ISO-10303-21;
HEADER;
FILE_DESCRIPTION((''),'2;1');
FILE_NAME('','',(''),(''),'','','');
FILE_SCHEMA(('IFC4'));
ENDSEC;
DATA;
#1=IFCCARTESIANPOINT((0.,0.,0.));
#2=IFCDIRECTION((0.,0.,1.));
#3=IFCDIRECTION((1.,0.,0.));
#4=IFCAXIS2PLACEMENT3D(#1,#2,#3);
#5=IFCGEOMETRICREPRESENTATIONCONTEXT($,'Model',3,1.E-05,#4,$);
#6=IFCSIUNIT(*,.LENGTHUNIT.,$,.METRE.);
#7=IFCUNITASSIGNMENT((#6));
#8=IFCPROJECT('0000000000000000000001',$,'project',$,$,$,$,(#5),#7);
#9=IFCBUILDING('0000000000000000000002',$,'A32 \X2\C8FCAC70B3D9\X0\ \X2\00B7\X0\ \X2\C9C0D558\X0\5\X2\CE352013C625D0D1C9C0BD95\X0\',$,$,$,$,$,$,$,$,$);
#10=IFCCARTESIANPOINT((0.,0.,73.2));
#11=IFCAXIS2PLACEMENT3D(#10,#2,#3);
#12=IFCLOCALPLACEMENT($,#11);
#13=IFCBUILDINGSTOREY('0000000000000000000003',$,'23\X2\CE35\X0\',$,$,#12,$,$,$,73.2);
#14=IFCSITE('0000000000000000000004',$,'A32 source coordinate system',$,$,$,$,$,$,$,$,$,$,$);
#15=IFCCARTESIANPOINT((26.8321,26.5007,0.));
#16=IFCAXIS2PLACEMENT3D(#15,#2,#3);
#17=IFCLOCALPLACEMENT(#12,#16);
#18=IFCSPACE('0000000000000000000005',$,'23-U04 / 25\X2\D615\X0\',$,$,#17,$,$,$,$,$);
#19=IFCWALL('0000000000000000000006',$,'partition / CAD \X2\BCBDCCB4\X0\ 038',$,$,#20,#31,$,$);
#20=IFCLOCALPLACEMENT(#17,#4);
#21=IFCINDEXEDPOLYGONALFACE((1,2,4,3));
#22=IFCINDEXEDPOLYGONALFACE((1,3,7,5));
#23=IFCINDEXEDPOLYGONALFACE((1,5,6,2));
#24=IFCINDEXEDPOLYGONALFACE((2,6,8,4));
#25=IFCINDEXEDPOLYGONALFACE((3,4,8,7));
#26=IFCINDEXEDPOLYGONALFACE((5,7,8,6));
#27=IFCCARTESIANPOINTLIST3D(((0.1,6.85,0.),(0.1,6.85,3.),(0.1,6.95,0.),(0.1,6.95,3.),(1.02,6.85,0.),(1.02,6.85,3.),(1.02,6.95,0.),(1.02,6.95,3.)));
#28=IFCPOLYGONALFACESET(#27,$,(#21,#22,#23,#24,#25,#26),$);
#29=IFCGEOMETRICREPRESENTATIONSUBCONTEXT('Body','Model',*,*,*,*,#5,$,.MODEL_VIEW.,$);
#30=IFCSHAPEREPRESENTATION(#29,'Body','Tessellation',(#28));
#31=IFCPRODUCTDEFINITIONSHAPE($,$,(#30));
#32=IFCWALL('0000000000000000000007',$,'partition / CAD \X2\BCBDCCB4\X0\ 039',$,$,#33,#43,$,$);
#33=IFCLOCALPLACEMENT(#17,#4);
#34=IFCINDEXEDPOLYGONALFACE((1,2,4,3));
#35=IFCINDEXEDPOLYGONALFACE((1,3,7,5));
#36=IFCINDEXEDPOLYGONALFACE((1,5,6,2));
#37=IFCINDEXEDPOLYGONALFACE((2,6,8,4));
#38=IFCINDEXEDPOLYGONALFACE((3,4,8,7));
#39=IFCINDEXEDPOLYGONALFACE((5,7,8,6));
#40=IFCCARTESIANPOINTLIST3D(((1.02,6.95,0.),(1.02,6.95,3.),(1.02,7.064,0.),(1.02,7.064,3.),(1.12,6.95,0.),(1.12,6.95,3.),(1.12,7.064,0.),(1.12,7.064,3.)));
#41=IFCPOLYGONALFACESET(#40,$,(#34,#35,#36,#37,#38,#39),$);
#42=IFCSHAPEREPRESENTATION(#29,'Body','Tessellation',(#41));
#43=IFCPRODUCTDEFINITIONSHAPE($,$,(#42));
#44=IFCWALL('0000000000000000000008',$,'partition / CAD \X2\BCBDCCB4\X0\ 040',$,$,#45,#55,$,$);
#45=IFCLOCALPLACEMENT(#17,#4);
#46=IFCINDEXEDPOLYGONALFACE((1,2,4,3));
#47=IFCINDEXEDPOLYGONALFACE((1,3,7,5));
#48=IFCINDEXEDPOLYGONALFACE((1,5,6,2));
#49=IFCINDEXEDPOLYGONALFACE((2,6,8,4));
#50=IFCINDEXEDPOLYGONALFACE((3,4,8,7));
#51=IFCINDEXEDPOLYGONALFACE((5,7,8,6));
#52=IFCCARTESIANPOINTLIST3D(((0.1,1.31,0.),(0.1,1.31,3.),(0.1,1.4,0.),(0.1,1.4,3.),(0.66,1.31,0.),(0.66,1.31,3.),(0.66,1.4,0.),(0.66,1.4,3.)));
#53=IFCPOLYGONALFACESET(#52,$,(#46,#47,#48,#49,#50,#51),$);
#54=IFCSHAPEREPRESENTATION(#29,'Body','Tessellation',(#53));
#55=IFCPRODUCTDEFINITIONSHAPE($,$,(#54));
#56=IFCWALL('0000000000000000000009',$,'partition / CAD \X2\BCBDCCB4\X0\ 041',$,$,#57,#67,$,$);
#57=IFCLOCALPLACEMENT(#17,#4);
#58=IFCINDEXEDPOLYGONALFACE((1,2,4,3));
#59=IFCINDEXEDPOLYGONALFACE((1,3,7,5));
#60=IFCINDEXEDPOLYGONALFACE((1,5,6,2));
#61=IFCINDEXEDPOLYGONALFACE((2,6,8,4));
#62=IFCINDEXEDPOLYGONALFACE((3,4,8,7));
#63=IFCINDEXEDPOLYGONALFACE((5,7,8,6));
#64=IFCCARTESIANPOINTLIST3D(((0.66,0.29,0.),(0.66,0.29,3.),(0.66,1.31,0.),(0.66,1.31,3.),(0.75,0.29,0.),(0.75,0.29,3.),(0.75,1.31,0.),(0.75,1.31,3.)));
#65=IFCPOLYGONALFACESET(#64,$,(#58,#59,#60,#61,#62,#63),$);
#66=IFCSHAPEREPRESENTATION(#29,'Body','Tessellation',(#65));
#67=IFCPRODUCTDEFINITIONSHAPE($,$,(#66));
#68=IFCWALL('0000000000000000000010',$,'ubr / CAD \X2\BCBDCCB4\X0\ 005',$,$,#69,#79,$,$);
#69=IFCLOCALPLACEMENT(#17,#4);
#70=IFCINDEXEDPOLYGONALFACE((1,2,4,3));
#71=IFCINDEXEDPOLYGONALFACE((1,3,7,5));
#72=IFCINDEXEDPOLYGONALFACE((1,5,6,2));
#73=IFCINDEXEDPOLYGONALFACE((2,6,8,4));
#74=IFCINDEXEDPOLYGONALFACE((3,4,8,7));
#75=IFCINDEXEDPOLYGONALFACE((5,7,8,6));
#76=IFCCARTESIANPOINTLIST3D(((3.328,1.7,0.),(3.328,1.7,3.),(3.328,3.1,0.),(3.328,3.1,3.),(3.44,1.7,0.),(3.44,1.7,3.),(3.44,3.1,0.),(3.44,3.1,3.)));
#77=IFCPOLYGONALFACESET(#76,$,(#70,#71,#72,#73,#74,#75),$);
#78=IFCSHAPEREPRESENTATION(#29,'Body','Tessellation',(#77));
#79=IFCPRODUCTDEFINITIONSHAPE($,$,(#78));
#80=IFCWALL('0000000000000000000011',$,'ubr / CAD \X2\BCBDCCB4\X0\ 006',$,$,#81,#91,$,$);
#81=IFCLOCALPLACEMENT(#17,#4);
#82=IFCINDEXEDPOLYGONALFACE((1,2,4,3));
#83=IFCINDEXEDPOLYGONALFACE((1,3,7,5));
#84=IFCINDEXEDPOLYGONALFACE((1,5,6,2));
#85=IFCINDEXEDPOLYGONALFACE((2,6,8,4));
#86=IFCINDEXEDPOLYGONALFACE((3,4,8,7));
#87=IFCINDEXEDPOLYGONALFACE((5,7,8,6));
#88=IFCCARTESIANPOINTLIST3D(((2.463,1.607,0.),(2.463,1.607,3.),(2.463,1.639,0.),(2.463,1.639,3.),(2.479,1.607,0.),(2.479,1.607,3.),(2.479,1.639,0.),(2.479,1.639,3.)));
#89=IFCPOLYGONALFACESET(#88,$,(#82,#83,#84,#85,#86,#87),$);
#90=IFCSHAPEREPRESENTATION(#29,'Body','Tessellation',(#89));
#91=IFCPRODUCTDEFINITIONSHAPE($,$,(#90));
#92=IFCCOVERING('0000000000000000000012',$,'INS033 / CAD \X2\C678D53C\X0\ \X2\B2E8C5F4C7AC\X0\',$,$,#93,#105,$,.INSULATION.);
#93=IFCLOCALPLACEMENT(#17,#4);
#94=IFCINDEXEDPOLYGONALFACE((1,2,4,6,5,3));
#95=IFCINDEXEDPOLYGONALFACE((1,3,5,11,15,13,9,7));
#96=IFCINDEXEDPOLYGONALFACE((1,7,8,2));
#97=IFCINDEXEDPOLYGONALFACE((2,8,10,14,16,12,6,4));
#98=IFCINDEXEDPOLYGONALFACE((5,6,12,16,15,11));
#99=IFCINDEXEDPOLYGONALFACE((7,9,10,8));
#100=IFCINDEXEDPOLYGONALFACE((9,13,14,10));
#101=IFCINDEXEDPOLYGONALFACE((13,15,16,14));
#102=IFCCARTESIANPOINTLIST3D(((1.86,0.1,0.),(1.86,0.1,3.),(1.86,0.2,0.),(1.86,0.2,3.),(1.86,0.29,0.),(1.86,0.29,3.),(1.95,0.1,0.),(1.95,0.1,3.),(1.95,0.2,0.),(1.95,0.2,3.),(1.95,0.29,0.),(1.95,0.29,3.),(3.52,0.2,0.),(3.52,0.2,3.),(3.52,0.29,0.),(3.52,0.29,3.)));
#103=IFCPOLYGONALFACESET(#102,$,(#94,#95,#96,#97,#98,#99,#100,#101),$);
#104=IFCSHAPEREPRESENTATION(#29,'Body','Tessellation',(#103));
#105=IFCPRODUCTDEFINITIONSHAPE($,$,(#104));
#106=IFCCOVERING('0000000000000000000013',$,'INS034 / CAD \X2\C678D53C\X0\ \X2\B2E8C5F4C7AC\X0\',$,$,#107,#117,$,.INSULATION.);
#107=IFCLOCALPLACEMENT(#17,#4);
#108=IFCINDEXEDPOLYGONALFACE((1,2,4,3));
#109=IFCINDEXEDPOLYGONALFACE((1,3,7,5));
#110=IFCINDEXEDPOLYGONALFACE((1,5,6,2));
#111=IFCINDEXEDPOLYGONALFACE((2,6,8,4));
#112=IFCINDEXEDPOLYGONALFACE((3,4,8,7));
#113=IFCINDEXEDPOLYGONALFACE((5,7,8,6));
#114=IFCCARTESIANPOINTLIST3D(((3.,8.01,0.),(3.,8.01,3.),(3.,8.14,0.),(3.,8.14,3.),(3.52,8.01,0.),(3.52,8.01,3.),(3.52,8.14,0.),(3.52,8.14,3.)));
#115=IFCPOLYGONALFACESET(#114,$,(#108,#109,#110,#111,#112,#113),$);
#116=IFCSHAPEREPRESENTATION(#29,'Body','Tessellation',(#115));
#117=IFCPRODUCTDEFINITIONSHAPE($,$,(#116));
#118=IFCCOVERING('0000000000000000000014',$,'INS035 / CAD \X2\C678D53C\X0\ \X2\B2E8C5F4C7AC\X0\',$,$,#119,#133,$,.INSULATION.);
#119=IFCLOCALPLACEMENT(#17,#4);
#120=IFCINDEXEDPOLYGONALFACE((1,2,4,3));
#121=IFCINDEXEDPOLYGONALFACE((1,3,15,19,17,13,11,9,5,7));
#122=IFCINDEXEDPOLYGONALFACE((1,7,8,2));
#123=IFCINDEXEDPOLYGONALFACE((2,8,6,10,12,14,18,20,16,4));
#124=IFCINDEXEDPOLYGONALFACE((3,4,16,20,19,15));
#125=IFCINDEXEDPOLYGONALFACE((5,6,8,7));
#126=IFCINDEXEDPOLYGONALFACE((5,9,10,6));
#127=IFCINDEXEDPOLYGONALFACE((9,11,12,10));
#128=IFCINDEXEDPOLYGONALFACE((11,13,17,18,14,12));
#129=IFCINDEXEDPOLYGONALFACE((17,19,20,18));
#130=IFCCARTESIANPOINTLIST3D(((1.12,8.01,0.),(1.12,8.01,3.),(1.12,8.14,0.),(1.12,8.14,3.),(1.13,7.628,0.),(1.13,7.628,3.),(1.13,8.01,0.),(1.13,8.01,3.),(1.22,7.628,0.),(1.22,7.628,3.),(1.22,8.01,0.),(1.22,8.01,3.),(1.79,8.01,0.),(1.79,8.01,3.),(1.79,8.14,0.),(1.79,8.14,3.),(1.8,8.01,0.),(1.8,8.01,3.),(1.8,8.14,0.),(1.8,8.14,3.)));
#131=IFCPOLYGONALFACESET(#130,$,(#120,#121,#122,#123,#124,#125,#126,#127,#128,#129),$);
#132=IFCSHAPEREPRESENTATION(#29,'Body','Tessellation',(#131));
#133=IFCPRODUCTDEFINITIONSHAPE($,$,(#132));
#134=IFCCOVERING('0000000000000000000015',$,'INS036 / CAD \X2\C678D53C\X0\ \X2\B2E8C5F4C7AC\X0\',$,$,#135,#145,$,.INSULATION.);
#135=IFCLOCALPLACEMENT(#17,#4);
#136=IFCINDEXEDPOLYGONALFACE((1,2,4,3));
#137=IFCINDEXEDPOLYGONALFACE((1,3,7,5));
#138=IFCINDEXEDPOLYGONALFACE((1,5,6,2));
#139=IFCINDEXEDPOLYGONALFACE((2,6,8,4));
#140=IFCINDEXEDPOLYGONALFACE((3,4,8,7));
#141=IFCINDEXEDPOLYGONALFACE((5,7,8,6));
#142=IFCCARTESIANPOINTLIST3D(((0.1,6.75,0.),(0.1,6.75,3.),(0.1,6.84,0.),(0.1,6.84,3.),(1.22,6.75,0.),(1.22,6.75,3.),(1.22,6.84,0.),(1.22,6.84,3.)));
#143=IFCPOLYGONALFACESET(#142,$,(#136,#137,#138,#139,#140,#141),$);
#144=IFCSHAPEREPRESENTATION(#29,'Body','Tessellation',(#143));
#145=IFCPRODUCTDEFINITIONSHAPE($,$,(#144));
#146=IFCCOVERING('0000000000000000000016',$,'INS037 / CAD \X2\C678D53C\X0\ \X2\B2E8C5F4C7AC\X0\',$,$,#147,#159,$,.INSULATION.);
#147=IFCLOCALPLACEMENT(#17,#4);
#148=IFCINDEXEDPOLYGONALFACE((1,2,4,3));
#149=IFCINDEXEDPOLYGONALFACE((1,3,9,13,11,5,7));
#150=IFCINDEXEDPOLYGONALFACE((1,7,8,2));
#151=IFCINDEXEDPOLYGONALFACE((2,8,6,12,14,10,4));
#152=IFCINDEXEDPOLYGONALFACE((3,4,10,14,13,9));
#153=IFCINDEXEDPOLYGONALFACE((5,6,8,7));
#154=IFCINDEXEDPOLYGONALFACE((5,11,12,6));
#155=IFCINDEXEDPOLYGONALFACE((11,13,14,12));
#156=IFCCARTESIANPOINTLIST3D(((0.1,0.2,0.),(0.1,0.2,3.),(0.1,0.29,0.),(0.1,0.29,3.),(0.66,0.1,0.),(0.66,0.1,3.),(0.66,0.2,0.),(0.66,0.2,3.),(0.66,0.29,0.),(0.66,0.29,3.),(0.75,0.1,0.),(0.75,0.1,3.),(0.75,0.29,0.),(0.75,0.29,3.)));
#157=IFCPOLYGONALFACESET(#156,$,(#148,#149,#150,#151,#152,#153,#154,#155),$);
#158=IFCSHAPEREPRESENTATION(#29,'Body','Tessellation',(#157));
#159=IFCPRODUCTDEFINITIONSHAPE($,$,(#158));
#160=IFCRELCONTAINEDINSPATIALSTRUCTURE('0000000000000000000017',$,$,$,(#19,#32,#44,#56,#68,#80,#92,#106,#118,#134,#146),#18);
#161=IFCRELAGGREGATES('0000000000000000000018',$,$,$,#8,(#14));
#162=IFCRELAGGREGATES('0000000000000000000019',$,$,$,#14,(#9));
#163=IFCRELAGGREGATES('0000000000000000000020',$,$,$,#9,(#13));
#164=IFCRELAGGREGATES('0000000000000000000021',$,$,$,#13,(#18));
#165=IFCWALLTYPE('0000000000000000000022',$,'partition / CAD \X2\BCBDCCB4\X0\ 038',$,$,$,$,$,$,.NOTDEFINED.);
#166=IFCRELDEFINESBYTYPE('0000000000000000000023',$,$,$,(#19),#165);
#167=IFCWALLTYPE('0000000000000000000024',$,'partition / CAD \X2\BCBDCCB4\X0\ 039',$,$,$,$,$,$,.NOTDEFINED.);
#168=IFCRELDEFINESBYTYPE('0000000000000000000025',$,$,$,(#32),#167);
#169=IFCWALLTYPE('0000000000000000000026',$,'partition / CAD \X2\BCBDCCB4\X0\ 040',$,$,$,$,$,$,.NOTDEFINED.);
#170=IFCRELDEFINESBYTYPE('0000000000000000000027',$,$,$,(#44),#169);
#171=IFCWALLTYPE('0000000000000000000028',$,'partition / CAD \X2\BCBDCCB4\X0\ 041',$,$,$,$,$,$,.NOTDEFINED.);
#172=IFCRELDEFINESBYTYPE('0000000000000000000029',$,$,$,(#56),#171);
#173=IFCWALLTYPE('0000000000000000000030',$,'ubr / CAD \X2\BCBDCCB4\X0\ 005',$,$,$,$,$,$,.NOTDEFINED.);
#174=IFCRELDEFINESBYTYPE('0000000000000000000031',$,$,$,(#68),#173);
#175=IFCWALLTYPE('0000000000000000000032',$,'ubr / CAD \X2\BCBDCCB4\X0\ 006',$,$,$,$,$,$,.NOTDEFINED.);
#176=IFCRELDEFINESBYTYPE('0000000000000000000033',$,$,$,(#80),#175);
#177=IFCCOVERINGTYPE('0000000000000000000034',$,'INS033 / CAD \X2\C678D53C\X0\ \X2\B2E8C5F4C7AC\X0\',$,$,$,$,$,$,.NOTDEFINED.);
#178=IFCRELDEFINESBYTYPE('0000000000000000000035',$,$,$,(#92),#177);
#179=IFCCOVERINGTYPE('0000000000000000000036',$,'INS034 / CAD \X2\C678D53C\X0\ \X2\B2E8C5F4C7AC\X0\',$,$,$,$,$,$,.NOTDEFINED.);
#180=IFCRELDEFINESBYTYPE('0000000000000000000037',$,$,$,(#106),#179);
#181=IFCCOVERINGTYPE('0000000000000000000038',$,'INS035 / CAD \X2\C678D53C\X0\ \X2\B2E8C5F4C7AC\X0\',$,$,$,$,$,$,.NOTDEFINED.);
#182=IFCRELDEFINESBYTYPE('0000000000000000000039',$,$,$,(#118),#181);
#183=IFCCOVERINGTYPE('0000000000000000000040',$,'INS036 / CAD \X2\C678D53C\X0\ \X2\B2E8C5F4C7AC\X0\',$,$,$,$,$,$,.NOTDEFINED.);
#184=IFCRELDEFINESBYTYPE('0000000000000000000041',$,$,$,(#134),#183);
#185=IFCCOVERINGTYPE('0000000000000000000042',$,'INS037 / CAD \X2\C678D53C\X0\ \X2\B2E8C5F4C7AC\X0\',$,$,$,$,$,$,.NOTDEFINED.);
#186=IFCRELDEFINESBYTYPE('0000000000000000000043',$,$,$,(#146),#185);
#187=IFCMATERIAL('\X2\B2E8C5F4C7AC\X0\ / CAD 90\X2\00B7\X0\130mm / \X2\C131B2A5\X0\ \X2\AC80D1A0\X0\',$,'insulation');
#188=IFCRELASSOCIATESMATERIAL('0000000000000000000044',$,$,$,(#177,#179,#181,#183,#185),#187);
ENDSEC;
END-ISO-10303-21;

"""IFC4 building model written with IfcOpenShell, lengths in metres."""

from ifc_helpers import new_model, si_unit, frame, origin, origin_with_axes, place, context, subcontext, project, spatial, polyline, outline, extrude, source, transform, mapped, material, type_object, type_shapes, element, save


model = new_model("IFC4")

# Units and contexts
model_context = context("Model", 3, precision=1e-05, world=origin_with_axes())
body_context = subcontext(model_context, "Body", "Model", "MODEL_VIEW")
ifc_project = project(units=[si_unit("LENGTHUNIT", "METRE")], contexts=[model_context])

# Site, building, storey, space
storey_placement = place(None, frame((0.0, 0.0, 73.2), z_axis=(0.0, 0.0, 1.0), x_axis=(1.0, 0.0, 0.0)))
space_placement = place(storey_placement, frame((26.8321, 26.5007, 0.0), z_axis=(0.0, 0.0, 1.0), x_axis=(1.0, 0.0, 0.0)))
site = spatial("IfcSite", under=ifc_project, Name="A32 source coordinate system")
building = spatial("IfcBuilding", under=site, Name="A32 주거동 · 지하5층–옥탑지붕")
storey = spatial("IfcBuildingStorey", under=building, at=storey_placement, Name="23층", Elevation=73.2)
space = spatial("IfcSpace", under=storey, at=space_placement, Name="23-U04 / 25형")

# Walls
wall_type_1 = type_object("IfcWallType", Name="partition / CAD 벽체 038", PredefinedType="NOTDEFINED")
shared_shape_1 = source(origin(), body_context, "Body", "SweptSolid", [
    extrude(outline(polyline([(0.1, 6.95), (1.02, 6.95), (1.02, 6.85), (0.1, 6.85), (0.1, 6.95)])), origin(), (0.0, 0.0, 1.0), 3.0),
])
type_shapes(wall_type_1, [shared_shape_1])
wall_1_placement = place(space_placement, origin_with_axes())
element("IfcWall", 1, at=wall_1_placement, inside=space, type_object=wall_type_1, Name="partition / CAD 벽체 038", context=body_context, shape_type="MappedRepresentation", body=[
    mapped(shared_shape_1, transform((0.0, 0.0, 0.0), scale=1.0)),
])
wall_type_2 = type_object("IfcWallType", Name="partition / CAD 벽체 039", PredefinedType="NOTDEFINED")
shared_shape_2 = source(origin(), body_context, "Body", "SweptSolid", [
    extrude(outline(polyline([(1.02, 6.95), (1.02, 7.064), (1.12, 7.064), (1.12, 6.95), (1.02, 6.95)])), origin(), (0.0, 0.0, 1.0), 3.0),
])
type_shapes(wall_type_2, [shared_shape_2])
wall_2_placement = place(space_placement, origin_with_axes())
element("IfcWall", 2, at=wall_2_placement, inside=space, type_object=wall_type_2, Name="partition / CAD 벽체 039", context=body_context, shape_type="MappedRepresentation", body=[
    mapped(shared_shape_2, transform((0.0, 0.0, 0.0), scale=1.0)),
])
wall_type_3 = type_object("IfcWallType", Name="partition / CAD 벽체 040", PredefinedType="NOTDEFINED")
shared_shape_3 = source(origin(), body_context, "Body", "SweptSolid", [
    extrude(outline(polyline([(0.1, 1.4), (0.66, 1.4), (0.66, 1.31), (0.1, 1.31), (0.1, 1.4)])), origin(), (0.0, 0.0, 1.0), 3.0),
])
type_shapes(wall_type_3, [shared_shape_3])
wall_3_placement = place(space_placement, origin_with_axes())
element("IfcWall", 3, at=wall_3_placement, inside=space, type_object=wall_type_3, Name="partition / CAD 벽체 040", context=body_context, shape_type="MappedRepresentation", body=[
    mapped(shared_shape_3, transform((0.0, 0.0, 0.0), scale=1.0)),
])
wall_type_4 = type_object("IfcWallType", Name="partition / CAD 벽체 041", PredefinedType="NOTDEFINED")
shared_shape_4 = source(origin(), body_context, "Body", "SweptSolid", [
    extrude(outline(polyline([(0.75, 1.31), (0.75, 0.29), (0.66, 0.29), (0.66, 1.31), (0.75, 1.31)])), origin(), (0.0, 0.0, 1.0), 3.0),
])
type_shapes(wall_type_4, [shared_shape_4])
wall_4_placement = place(space_placement, origin_with_axes())
element("IfcWall", 4, at=wall_4_placement, inside=space, type_object=wall_type_4, Name="partition / CAD 벽체 041", context=body_context, shape_type="MappedRepresentation", body=[
    mapped(shared_shape_4, transform((0.0, 0.0, 0.0), scale=1.0)),
])
wall_type_5 = type_object("IfcWallType", Name="ubr / CAD 벽체 005", PredefinedType="NOTDEFINED")
shared_shape_5 = source(origin(), body_context, "Body", "SweptSolid", [
    extrude(outline(polyline([(3.44, 3.1), (3.44, 1.7), (3.328, 1.7), (3.328, 3.1), (3.44, 3.1)])), origin(), (0.0, 0.0, 1.0), 3.0),
])
type_shapes(wall_type_5, [shared_shape_5])
wall_5_placement = place(space_placement, origin_with_axes())
element("IfcWall", 5, at=wall_5_placement, inside=space, type_object=wall_type_5, Name="ubr / CAD 벽체 005", context=body_context, shape_type="MappedRepresentation", body=[
    mapped(shared_shape_5, transform((0.0, 0.0, 0.0), scale=1.0)),
])
wall_type_6 = type_object("IfcWallType", Name="ubr / CAD 벽체 006", PredefinedType="NOTDEFINED")
shared_shape_6 = source(origin(), body_context, "Body", "SweptSolid", [
    extrude(outline(polyline([(2.463, 1.639), (2.479, 1.639), (2.479, 1.607), (2.463, 1.607), (2.463, 1.639)])), origin(), (0.0, 0.0, 1.0), 3.0),
])
type_shapes(wall_type_6, [shared_shape_6])
wall_6_placement = place(space_placement, origin_with_axes())
element("IfcWall", 6, at=wall_6_placement, inside=space, type_object=wall_type_6, Name="ubr / CAD 벽체 006", context=body_context, shape_type="MappedRepresentation", body=[
    mapped(shared_shape_6, transform((0.0, 0.0, 0.0), scale=1.0)),
])

# Coverings
ifc_material = material(Name="단열재 / CAD 90·130mm / 성능 검토", Category="insulation")
covering_type_1 = type_object("IfcCoveringType", Name="INS033 / CAD 외피 단열재", PredefinedType="NOTDEFINED", material=ifc_material)
shared_shape_7 = source(origin(), body_context, "Body", "SweptSolid", [
    extrude(outline(polyline([(1.95, 0.29), (3.52, 0.29), (3.52, 0.2), (1.95, 0.2), (1.95, 0.1), (1.86, 0.1), (1.86, 0.2), (1.86, 0.29), (1.95, 0.29)])), origin(), (0.0, 0.0, 1.0), 3.0),
])
type_shapes(covering_type_1, [shared_shape_7])
covering_1_placement = place(space_placement, origin_with_axes())
element("IfcCovering", 7, at=covering_1_placement, inside=space, type_object=covering_type_1, Name="INS033 / CAD 외피 단열재", PredefinedType="INSULATION", context=body_context, shape_type="MappedRepresentation", body=[
    mapped(shared_shape_7, transform((0.0, 0.0, 0.0), scale=1.0)),
])
covering_type_2 = type_object("IfcCoveringType", Name="INS034 / CAD 외피 단열재", PredefinedType="NOTDEFINED", material=ifc_material)
shared_shape_8 = source(origin(), body_context, "Body", "SweptSolid", [
    extrude(outline(polyline([(3.52, 8.01), (3.0, 8.01), (3.0, 8.14), (3.52, 8.14), (3.52, 8.01)])), origin(), (0.0, 0.0, 1.0), 3.0),
])
type_shapes(covering_type_2, [shared_shape_8])
covering_2_placement = place(space_placement, origin_with_axes())
element("IfcCovering", 8, at=covering_2_placement, inside=space, type_object=covering_type_2, Name="INS034 / CAD 외피 단열재", PredefinedType="INSULATION", context=body_context, shape_type="MappedRepresentation", body=[
    mapped(shared_shape_8, transform((0.0, 0.0, 0.0), scale=1.0)),
])
covering_type_3 = type_object("IfcCoveringType", Name="INS035 / CAD 외피 단열재", PredefinedType="NOTDEFINED", material=ifc_material)
shared_shape_9 = source(origin(), body_context, "Body", "SweptSolid", [
    extrude(outline(polyline([(1.8, 8.01), (1.79, 8.01), (1.22, 8.01), (1.22, 7.628), (1.13, 7.628), (1.13, 8.01), (1.12, 8.01), (1.12, 8.14), (1.79, 8.14), (1.8, 8.14), (1.8, 8.01)])), origin(), (0.0, 0.0, 1.0), 3.0),
])
type_shapes(covering_type_3, [shared_shape_9])
covering_3_placement = place(space_placement, origin_with_axes())
element("IfcCovering", 9, at=covering_3_placement, inside=space, type_object=covering_type_3, Name="INS035 / CAD 외피 단열재", PredefinedType="INSULATION", context=body_context, shape_type="MappedRepresentation", body=[
    mapped(shared_shape_9, transform((0.0, 0.0, 0.0), scale=1.0)),
])
covering_type_4 = type_object("IfcCoveringType", Name="INS036 / CAD 외피 단열재", PredefinedType="NOTDEFINED", material=ifc_material)
shared_shape_10 = source(origin(), body_context, "Body", "SweptSolid", [
    extrude(outline(polyline([(1.22, 6.84), (1.22, 6.75), (0.1, 6.75), (0.1, 6.84), (1.22, 6.84)])), origin(), (0.0, 0.0, 1.0), 3.0),
])
type_shapes(covering_type_4, [shared_shape_10])
covering_4_placement = place(space_placement, origin_with_axes())
element("IfcCovering", 10, at=covering_4_placement, inside=space, type_object=covering_type_4, Name="INS036 / CAD 외피 단열재", PredefinedType="INSULATION", context=body_context, shape_type="MappedRepresentation", body=[
    mapped(shared_shape_10, transform((0.0, 0.0, 0.0), scale=1.0)),
])
covering_type_5 = type_object("IfcCoveringType", Name="INS037 / CAD 외피 단열재", PredefinedType="NOTDEFINED", material=ifc_material)
shared_shape_11 = source(origin(), body_context, "Body", "SweptSolid", [
    extrude(outline(polyline([(0.1, 0.2), (0.1, 0.29), (0.66, 0.29), (0.75, 0.29), (0.75, 0.1), (0.66, 0.1), (0.66, 0.2), (0.1, 0.2)])), origin(), (0.0, 0.0, 1.0), 3.0),
])
type_shapes(covering_type_5, [shared_shape_11])
covering_5_placement = place(space_placement, origin_with_axes())
element("IfcCovering", 11, at=covering_5_placement, inside=space, type_object=covering_type_5, Name="INS037 / CAD 외피 단열재", PredefinedType="INSULATION", context=body_context, shape_type="MappedRepresentation", body=[
    mapped(shared_shape_11, transform((0.0, 0.0, 0.0), scale=1.0)),
])

save(model, "model.ifc")
